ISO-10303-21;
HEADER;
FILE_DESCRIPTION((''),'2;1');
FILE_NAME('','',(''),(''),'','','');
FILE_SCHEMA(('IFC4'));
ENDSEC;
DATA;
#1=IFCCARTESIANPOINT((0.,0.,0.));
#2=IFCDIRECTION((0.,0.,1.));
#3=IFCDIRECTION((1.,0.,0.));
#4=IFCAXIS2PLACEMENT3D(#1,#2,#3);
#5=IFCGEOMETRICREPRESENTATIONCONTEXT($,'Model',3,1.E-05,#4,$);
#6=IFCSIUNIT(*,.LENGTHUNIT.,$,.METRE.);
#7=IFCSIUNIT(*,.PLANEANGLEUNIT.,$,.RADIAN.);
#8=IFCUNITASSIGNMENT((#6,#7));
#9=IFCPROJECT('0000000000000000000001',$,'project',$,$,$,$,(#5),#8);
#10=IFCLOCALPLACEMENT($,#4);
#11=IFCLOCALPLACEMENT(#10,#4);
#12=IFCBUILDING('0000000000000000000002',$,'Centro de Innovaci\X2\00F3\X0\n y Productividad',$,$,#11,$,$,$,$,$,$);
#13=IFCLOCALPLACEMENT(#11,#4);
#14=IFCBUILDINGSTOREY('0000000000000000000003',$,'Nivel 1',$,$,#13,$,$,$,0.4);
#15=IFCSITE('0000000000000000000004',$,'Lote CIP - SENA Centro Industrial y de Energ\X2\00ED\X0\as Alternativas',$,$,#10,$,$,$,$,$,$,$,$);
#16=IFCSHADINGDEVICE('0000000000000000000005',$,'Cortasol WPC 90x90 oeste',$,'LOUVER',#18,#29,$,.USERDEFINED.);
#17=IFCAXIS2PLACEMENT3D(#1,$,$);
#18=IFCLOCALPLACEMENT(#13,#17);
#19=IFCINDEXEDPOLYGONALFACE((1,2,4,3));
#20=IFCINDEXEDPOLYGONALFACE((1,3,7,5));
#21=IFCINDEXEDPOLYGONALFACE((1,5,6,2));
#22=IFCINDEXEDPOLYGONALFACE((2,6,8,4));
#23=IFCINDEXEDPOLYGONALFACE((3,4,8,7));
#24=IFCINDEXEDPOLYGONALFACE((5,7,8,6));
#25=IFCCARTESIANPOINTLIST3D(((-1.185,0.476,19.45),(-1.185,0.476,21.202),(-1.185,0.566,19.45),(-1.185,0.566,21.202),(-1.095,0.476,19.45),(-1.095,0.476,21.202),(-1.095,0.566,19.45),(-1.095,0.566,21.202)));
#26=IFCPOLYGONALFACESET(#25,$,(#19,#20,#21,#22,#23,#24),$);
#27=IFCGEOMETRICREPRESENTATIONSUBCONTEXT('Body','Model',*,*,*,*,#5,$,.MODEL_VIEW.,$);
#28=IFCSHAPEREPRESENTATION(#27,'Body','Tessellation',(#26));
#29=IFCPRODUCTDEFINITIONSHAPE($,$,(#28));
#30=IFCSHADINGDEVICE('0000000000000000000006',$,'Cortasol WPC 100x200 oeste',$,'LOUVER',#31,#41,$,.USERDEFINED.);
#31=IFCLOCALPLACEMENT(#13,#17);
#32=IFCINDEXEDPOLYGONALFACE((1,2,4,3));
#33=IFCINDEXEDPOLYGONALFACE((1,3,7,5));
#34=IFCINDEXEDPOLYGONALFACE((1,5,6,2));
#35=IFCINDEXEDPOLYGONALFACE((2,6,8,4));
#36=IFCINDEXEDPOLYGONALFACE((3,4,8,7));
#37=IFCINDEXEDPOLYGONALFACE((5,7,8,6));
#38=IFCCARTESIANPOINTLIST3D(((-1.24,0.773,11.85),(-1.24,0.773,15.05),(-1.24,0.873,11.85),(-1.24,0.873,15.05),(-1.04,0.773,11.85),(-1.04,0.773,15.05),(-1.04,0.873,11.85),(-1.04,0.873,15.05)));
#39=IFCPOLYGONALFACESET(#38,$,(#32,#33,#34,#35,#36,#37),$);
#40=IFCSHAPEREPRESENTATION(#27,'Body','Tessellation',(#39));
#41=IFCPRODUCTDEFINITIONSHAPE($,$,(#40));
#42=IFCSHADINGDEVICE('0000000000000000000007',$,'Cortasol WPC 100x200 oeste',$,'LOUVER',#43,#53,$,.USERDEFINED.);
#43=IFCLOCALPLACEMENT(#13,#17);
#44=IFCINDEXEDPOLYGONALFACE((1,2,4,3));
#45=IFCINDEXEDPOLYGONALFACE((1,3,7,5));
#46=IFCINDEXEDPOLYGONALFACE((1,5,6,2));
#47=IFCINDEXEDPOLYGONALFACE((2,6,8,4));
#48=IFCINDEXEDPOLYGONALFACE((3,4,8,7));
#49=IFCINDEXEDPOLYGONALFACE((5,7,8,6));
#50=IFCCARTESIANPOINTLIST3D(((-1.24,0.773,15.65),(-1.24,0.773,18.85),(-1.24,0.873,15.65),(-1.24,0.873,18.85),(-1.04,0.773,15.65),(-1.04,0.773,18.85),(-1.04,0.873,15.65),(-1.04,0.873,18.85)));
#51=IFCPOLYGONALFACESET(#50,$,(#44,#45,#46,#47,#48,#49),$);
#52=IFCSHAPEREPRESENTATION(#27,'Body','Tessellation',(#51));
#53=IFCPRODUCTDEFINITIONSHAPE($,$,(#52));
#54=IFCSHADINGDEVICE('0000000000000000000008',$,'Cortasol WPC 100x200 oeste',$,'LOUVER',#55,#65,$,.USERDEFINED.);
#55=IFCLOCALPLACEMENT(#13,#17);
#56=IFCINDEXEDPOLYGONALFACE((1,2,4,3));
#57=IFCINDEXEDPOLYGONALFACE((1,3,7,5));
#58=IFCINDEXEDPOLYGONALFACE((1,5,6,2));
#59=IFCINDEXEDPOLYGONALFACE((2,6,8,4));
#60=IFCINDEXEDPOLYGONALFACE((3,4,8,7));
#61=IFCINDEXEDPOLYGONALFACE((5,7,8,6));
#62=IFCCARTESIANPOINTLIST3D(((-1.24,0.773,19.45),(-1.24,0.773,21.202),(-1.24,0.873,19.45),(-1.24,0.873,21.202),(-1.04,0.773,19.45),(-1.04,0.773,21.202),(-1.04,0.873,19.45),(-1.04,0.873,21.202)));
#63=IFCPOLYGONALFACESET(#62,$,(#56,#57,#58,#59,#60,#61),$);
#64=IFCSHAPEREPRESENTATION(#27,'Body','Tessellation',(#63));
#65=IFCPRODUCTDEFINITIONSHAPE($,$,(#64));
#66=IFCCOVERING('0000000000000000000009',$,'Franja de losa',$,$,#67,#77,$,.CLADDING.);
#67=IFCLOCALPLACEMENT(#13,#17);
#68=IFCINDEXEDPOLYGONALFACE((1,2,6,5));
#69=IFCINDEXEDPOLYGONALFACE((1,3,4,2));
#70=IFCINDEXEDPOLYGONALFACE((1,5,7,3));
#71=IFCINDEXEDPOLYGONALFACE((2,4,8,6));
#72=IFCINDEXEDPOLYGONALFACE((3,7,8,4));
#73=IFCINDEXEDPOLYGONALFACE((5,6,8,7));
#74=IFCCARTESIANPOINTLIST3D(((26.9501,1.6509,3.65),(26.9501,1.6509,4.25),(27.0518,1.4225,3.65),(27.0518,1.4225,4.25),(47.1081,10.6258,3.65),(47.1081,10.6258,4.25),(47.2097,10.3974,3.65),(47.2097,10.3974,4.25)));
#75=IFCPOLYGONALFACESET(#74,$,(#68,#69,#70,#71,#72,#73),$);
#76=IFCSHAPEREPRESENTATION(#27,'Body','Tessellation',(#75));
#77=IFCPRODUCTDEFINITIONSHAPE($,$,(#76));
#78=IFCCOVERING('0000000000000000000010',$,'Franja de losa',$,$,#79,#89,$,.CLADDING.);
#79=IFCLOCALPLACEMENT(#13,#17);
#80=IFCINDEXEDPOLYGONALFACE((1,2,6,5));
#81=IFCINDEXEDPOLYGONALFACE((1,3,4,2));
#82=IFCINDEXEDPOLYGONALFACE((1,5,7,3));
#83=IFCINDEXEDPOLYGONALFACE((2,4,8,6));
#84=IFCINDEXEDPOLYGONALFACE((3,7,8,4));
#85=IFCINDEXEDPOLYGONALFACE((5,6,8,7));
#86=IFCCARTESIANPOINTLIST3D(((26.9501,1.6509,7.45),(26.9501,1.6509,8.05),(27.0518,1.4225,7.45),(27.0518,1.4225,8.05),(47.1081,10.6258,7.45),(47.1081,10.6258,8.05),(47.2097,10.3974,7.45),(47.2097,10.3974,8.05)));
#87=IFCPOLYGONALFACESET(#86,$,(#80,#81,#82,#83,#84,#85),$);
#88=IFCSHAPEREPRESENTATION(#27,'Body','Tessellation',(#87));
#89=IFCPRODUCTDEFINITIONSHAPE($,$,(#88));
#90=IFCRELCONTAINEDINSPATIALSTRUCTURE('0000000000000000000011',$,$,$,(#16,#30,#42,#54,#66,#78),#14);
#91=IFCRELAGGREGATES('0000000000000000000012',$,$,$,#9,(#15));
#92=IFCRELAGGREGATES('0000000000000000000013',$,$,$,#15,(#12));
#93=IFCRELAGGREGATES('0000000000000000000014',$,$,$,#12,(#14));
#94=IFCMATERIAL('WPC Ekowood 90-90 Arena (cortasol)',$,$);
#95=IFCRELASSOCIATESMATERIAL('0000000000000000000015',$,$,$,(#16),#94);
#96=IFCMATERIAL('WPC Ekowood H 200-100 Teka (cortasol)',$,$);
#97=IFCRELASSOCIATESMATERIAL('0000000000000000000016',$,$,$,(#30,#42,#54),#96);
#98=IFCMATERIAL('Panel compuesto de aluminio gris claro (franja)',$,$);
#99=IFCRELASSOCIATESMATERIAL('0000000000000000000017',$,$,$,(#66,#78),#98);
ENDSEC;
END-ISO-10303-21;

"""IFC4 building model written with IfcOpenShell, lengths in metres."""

from ifc_helpers import new_model, si_unit, frame, origin_with_axes, place, context, subcontext, project, spatial, polyline, outline, extrude, material, element, save


model = new_model("IFC4")

# Units and contexts
model_context = context("Model", 3, precision=1e-05, world=origin_with_axes())
body_context = subcontext(model_context, "Body", "Model", "MODEL_VIEW")
ifc_project = project(units=[si_unit("LENGTHUNIT", "METRE"), si_unit("PLANEANGLEUNIT", "RADIAN")], contexts=[model_context])

# Site, building, storey
site_placement = place(None, origin_with_axes())
site = spatial("IfcSite", under=ifc_project, at=site_placement, Name="Lote CIP - SENA Centro Industrial y de Energías Alternativas")
building_placement = place(site_placement, origin_with_axes())
building = spatial("IfcBuilding", under=site, at=building_placement, Name="Centro de Innovación y Productividad")
storey_placement = place(building_placement, origin_with_axes())
storey = spatial("IfcBuildingStorey", under=building, at=storey_placement, Name="Nivel 1", Elevation=0.4)

# Shading devices
ifc_material_1 = material(Name="WPC Ekowood H 200-100 Teka (cortasol)")
ifc_material_2 = material(Name="WPC Ekowood 90-90 Arena (cortasol)")
shading_device_1_placement = place(storey_placement, origin_with_axes())
element("IfcShadingDevice", 1, at=shading_device_1_placement, inside=storey, material=ifc_material_2, Name="Cortasol WPC 90x90 oeste", ObjectType="LOUVER", PredefinedType="USERDEFINED", context=body_context, shape_type="SweptSolid", body=[
    extrude(outline(polyline([(-1.095, 0.476), (-1.185, 0.476), (-1.185, 0.566), (-1.095, 0.566), (-1.095, 0.476)])), frame((0.0, 0.0, 19.45)), (0.0, 0.0, 1.0), 1.752),
])
shading_device_2_placement = place(storey_placement, origin_with_axes())
element("IfcShadingDevice", 2, at=shading_device_2_placement, inside=storey, material=ifc_material_1, Name="Cortasol WPC 100x200 oeste", ObjectType="LOUVER", PredefinedType="USERDEFINED", context=body_context, shape_type="SweptSolid", body=[
    extrude(outline(polyline([(-1.04, 0.773), (-1.24, 0.773), (-1.24, 0.873), (-1.04, 0.873), (-1.04, 0.773)])), frame((0.0, 0.0, 11.85)), (0.0, 0.0, 1.0), 3.2),
])
shading_device_3_placement = place(storey_placement, origin_with_axes())
element("IfcShadingDevice", 3, at=shading_device_3_placement, inside=storey, material=ifc_material_1, Name="Cortasol WPC 100x200 oeste", ObjectType="LOUVER", PredefinedType="USERDEFINED", context=body_context, shape_type="SweptSolid", body=[
    extrude(outline(polyline([(-1.04, 0.773), (-1.24, 0.773), (-1.24, 0.873), (-1.04, 0.873), (-1.04, 0.773)])), frame((0.0, 0.0, 15.65)), (0.0, 0.0, 1.0), 3.2),
])
shading_device_4_placement = place(storey_placement, origin_with_axes())
element("IfcShadingDevice", 4, at=shading_device_4_placement, inside=storey, material=ifc_material_1, Name="Cortasol WPC 100x200 oeste", ObjectType="LOUVER", PredefinedType="USERDEFINED", context=body_context, shape_type="SweptSolid", body=[
    extrude(outline(polyline([(-1.04, 0.773), (-1.24, 0.773), (-1.24, 0.873), (-1.04, 0.873), (-1.04, 0.773)])), frame((0.0, 0.0, 19.45)), (0.0, 0.0, 1.0), 1.752),
])

# Coverings
ifc_material_3 = material(Name="Panel compuesto de aluminio gris claro (franja)")
covering_1_placement = place(storey_placement, origin_with_axes())
element("IfcCovering", 5, at=covering_1_placement, inside=storey, material=ifc_material_3, Name="Franja de losa", PredefinedType="CLADDING", context=body_context, shape_type="SweptSolid", body=[
    extrude(outline(polyline([(27.0518, 1.4225), (26.9501, 1.6509), (47.1081, 10.6258), (47.2097, 10.3974), (27.0518, 1.4225)])), frame((0.0, 0.0, 3.65)), (0.0, 0.0, 1.0), 0.6),
])
covering_2_placement = place(storey_placement, origin_with_axes())
element("IfcCovering", 6, at=covering_2_placement, inside=storey, material=ifc_material_3, Name="Franja de losa", PredefinedType="CLADDING", context=body_context, shape_type="SweptSolid", body=[
    extrude(outline(polyline([(27.0518, 1.4225), (26.9501, 1.6509), (47.1081, 10.6258), (47.2097, 10.3974), (27.0518, 1.4225)])), frame((0.0, 0.0, 7.45)), (0.0, 0.0, 1.0), 0.6),
])

save(model, "model.ifc")
